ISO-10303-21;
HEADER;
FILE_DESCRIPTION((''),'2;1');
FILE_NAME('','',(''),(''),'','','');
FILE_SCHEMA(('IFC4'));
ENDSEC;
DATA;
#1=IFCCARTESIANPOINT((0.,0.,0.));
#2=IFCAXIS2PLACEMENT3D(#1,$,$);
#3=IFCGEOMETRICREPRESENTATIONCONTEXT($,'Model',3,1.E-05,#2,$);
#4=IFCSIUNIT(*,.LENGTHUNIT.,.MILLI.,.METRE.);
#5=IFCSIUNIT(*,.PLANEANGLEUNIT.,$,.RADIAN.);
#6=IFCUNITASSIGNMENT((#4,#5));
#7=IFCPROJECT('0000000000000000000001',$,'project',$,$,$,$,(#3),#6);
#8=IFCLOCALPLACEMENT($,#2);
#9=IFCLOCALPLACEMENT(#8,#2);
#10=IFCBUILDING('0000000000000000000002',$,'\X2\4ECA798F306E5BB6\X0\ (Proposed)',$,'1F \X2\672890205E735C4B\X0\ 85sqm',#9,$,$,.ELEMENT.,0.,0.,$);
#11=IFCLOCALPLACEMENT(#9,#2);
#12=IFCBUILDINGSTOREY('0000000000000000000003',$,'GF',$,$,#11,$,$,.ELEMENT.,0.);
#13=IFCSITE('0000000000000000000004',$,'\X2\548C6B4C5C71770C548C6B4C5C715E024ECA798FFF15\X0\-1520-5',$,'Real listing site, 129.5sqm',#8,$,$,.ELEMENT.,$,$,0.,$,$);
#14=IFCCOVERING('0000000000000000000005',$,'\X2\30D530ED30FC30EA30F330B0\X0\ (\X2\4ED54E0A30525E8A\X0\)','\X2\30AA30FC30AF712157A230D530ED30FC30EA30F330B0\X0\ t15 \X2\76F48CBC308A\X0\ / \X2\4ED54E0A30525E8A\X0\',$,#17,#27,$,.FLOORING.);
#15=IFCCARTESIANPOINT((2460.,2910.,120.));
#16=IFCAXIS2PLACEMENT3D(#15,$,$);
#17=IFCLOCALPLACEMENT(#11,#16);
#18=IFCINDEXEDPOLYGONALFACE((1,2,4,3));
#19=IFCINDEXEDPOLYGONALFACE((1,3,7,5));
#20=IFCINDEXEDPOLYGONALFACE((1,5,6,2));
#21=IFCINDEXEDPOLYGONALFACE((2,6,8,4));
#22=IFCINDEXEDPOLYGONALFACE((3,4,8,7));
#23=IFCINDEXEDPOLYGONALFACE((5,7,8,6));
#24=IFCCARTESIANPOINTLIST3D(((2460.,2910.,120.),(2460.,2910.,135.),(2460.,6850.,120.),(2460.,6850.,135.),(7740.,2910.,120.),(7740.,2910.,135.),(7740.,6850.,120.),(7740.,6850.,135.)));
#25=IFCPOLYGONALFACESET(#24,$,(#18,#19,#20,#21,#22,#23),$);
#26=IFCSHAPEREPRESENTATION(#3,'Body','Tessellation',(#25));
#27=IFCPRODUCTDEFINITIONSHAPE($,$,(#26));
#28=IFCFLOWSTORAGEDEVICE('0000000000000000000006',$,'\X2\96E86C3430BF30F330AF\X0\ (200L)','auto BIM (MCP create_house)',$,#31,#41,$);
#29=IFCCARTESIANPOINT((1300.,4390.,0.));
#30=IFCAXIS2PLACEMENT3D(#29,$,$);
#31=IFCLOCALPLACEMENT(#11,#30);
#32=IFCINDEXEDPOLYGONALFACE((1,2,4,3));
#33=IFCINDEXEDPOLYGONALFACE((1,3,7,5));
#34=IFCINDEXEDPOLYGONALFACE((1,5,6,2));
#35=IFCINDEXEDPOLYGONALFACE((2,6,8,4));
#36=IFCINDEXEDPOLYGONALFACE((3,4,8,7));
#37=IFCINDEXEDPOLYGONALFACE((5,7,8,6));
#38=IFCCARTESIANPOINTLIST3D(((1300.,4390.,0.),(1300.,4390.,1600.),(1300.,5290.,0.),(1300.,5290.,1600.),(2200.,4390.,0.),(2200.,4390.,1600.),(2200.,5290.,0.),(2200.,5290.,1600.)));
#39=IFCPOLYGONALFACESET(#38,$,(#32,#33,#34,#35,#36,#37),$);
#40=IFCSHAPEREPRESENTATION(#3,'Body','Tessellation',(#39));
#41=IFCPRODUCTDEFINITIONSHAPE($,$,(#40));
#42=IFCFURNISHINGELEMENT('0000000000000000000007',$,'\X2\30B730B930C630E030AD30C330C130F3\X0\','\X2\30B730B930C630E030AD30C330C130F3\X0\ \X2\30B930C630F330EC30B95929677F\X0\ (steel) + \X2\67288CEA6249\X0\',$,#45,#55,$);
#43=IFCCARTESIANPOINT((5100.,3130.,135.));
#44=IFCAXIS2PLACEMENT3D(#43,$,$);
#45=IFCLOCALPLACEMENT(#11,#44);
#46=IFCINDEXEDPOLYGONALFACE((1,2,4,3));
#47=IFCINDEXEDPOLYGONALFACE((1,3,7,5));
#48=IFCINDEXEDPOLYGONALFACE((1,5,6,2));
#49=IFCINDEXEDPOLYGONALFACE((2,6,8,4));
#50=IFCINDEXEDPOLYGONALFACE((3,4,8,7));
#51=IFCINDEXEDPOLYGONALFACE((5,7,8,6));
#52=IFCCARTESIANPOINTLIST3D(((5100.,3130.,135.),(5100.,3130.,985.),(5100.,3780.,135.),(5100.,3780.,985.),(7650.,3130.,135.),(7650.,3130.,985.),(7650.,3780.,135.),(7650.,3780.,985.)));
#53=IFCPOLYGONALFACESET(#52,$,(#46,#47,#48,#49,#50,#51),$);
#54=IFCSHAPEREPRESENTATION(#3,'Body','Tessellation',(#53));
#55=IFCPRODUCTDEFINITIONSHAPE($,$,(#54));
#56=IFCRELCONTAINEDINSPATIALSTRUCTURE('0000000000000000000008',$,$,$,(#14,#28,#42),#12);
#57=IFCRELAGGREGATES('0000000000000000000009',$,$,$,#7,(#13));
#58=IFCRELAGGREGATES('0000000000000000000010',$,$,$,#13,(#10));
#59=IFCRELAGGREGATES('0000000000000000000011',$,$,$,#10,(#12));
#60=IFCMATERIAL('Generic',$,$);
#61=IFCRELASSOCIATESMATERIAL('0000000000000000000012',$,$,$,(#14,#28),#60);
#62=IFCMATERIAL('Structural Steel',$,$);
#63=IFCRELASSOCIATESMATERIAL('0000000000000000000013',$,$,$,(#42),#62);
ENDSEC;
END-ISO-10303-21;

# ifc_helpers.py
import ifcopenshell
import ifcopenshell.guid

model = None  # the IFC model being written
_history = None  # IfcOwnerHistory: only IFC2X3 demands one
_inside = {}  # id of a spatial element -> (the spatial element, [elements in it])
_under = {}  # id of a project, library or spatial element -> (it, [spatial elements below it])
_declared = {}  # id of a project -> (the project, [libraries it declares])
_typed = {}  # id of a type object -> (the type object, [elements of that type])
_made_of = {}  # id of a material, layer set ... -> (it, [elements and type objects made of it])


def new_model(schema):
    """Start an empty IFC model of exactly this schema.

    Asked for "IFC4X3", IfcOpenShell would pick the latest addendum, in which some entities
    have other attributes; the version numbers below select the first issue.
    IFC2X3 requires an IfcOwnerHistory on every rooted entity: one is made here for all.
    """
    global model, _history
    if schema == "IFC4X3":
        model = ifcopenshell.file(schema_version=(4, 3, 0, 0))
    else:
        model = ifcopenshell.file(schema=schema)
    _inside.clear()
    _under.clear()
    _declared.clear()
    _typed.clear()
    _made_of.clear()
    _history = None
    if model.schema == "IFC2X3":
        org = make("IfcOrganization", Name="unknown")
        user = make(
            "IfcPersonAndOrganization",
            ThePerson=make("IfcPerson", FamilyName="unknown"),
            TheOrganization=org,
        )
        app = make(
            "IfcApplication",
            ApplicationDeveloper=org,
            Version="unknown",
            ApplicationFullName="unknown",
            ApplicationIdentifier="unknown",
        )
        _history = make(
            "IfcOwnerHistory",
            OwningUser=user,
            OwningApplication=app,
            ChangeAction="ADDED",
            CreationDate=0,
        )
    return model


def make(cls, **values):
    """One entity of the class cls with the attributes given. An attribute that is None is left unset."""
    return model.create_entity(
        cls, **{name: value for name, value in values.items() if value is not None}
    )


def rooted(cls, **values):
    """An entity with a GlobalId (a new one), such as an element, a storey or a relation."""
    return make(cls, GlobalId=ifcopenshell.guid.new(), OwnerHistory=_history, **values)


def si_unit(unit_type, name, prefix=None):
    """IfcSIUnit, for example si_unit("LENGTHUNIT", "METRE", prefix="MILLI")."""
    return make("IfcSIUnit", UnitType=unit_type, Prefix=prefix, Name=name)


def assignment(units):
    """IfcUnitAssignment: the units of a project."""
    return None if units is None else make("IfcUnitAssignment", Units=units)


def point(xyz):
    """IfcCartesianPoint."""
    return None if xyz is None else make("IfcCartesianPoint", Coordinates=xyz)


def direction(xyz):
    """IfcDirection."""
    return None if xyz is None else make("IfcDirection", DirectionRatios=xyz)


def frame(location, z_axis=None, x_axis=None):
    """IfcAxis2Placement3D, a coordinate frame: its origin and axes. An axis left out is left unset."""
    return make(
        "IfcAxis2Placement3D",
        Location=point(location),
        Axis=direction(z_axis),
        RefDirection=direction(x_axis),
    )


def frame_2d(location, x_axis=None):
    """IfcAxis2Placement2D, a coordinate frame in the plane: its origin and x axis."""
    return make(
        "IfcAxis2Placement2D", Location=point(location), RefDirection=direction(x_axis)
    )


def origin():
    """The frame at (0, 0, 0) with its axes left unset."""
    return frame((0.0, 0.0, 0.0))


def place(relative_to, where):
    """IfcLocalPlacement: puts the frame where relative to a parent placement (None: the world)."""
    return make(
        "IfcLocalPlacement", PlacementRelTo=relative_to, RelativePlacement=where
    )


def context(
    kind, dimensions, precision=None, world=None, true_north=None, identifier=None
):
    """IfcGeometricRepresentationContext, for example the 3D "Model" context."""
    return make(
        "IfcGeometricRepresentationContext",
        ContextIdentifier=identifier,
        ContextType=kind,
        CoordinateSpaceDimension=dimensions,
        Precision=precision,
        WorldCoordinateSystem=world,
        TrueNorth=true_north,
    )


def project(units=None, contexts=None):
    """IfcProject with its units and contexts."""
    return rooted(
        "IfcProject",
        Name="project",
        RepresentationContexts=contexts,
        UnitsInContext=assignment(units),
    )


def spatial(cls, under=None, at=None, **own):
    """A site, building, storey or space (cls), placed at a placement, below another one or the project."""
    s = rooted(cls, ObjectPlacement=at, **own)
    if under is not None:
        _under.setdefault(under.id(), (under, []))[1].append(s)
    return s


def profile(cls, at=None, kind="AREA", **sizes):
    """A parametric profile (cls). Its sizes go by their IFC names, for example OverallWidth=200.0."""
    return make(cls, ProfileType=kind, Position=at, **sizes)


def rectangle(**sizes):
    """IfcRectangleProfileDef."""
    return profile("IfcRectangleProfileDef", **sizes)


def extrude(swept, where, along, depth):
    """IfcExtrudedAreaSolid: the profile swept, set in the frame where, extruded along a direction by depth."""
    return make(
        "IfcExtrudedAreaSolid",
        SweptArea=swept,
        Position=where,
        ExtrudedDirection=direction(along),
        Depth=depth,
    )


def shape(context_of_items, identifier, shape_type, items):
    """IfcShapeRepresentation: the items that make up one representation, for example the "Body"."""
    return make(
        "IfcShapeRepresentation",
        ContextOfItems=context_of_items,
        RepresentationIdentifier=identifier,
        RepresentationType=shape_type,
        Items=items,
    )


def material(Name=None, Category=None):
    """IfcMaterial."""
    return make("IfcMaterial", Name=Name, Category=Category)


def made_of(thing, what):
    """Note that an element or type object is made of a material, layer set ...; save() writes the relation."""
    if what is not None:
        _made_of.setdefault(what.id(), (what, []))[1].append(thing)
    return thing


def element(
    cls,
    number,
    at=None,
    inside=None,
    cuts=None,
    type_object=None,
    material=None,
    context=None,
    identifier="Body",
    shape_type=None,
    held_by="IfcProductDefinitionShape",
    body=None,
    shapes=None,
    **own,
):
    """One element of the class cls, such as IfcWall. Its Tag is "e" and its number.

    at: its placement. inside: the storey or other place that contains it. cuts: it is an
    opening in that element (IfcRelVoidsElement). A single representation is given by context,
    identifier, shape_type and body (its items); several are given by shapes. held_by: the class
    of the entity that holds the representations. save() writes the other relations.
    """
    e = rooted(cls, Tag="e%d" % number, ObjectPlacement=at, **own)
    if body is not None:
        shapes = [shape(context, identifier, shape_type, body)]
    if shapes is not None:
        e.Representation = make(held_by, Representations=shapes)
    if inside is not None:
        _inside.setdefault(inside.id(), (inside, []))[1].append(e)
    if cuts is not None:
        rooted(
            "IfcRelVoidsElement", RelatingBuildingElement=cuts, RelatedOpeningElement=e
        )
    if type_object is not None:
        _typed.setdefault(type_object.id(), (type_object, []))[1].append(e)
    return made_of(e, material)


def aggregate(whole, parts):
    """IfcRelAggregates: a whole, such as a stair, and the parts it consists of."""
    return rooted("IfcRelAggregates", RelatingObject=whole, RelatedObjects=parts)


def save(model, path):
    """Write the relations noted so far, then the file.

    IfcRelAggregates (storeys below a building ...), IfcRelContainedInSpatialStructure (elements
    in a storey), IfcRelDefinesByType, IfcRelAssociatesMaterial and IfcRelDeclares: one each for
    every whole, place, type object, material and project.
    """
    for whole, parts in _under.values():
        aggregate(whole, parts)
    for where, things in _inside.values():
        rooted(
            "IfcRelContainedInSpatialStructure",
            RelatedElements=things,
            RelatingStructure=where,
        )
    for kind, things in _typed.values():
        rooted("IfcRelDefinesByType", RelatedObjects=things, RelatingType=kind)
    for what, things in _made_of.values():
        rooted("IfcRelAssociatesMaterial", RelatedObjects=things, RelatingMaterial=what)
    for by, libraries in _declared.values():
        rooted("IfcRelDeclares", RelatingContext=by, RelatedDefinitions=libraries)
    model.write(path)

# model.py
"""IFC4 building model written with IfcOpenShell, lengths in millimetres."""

from ifc_helpers import new_model, si_unit, frame, frame_2d, origin, place, context, project, spatial, rectangle, extrude, material, element, save


model = new_model("IFC4")

# Units and contexts
model_context = context("Model", 3, precision=1e-05, world=origin())
ifc_project = project(units=[si_unit("LENGTHUNIT", "METRE", prefix="MILLI"), si_unit("PLANEANGLEUNIT", "RADIAN")], contexts=[model_context])

# Site, building, storey
site_placement = place(None, origin())
site = spatial("IfcSite", under=ifc_project, at=site_placement, Name="和歌山県和歌山市今福５-1520-5", ObjectType="Real listing site, 129.5sqm", CompositionType="ELEMENT", RefElevation=0.0)
building_placement = place(site_placement, origin())
building = spatial("IfcBuilding", under=site, at=building_placement, Name="今福の家 (Proposed)", ObjectType="1F 木造平屋 85sqm", CompositionType="ELEMENT", ElevationOfRefHeight=0.0, ElevationOfTerrain=0.0)
storey_placement = place(building_placement, origin())
storey = spatial("IfcBuildingStorey", under=building, at=storey_placement, Name="GF", CompositionType="ELEMENT", Elevation=0.0)

# Shared definitions
ifc_material_1 = material(Name="Generic")

# Covering
covering_placement = place(storey_placement, frame((2460.0, 2910.0, 120.0)))
element("IfcCovering", 1, at=covering_placement, inside=storey, material=ifc_material_1, Name="フローリング (仕上げ床)", Description="オーク無垢フローリング t15 直貼り / 仕上げ床", PredefinedType="FLOORING", context=model_context, shape_type="SweptSolid", body=[
    extrude(rectangle(XDim=5280.0, YDim=3940.0, at=frame_2d((2640.0, 1970.0))), frame((2460.0, 2910.0, 120.0)), (0.0, 0.0, 1.0), 15.0),
])

# Flow storage device
flow_storage_device_placement = place(storey_placement, frame((1300.0, 4390.0, 0.0)))
element("IfcFlowStorageDevice", 2, at=flow_storage_device_placement, inside=storey, material=ifc_material_1, Name="雨水タンク (200L)", Description="auto BIM (MCP create_house)", context=model_context, shape_type="SweptSolid", body=[
    extrude(rectangle(XDim=900.0, YDim=900.0, at=frame_2d((450.0, 450.0))), frame((1300.0, 4390.0, 0.0)), (0.0, 0.0, 1.0), 1600.0),
])

# Furnishing element
ifc_material_2 = material(Name="Structural Steel")
furnishing_placement = place(storey_placement, frame((5100.0, 3130.0, 135.0)))
element("IfcFurnishingElement", 3, at=furnishing_placement, inside=storey, material=ifc_material_2, Name="システムキッチン", Description="システムキッチン ステンレス天板 (steel) + 木質扉", context=model_context, shape_type="SweptSolid", body=[
    extrude(rectangle(XDim=2550.0, YDim=650.0, at=frame_2d((1275.0, 325.0))), frame((5100.0, 3130.0, 135.0)), (0.0, 0.0, 1.0), 850.0),
])

save(model, "model.ifc")
